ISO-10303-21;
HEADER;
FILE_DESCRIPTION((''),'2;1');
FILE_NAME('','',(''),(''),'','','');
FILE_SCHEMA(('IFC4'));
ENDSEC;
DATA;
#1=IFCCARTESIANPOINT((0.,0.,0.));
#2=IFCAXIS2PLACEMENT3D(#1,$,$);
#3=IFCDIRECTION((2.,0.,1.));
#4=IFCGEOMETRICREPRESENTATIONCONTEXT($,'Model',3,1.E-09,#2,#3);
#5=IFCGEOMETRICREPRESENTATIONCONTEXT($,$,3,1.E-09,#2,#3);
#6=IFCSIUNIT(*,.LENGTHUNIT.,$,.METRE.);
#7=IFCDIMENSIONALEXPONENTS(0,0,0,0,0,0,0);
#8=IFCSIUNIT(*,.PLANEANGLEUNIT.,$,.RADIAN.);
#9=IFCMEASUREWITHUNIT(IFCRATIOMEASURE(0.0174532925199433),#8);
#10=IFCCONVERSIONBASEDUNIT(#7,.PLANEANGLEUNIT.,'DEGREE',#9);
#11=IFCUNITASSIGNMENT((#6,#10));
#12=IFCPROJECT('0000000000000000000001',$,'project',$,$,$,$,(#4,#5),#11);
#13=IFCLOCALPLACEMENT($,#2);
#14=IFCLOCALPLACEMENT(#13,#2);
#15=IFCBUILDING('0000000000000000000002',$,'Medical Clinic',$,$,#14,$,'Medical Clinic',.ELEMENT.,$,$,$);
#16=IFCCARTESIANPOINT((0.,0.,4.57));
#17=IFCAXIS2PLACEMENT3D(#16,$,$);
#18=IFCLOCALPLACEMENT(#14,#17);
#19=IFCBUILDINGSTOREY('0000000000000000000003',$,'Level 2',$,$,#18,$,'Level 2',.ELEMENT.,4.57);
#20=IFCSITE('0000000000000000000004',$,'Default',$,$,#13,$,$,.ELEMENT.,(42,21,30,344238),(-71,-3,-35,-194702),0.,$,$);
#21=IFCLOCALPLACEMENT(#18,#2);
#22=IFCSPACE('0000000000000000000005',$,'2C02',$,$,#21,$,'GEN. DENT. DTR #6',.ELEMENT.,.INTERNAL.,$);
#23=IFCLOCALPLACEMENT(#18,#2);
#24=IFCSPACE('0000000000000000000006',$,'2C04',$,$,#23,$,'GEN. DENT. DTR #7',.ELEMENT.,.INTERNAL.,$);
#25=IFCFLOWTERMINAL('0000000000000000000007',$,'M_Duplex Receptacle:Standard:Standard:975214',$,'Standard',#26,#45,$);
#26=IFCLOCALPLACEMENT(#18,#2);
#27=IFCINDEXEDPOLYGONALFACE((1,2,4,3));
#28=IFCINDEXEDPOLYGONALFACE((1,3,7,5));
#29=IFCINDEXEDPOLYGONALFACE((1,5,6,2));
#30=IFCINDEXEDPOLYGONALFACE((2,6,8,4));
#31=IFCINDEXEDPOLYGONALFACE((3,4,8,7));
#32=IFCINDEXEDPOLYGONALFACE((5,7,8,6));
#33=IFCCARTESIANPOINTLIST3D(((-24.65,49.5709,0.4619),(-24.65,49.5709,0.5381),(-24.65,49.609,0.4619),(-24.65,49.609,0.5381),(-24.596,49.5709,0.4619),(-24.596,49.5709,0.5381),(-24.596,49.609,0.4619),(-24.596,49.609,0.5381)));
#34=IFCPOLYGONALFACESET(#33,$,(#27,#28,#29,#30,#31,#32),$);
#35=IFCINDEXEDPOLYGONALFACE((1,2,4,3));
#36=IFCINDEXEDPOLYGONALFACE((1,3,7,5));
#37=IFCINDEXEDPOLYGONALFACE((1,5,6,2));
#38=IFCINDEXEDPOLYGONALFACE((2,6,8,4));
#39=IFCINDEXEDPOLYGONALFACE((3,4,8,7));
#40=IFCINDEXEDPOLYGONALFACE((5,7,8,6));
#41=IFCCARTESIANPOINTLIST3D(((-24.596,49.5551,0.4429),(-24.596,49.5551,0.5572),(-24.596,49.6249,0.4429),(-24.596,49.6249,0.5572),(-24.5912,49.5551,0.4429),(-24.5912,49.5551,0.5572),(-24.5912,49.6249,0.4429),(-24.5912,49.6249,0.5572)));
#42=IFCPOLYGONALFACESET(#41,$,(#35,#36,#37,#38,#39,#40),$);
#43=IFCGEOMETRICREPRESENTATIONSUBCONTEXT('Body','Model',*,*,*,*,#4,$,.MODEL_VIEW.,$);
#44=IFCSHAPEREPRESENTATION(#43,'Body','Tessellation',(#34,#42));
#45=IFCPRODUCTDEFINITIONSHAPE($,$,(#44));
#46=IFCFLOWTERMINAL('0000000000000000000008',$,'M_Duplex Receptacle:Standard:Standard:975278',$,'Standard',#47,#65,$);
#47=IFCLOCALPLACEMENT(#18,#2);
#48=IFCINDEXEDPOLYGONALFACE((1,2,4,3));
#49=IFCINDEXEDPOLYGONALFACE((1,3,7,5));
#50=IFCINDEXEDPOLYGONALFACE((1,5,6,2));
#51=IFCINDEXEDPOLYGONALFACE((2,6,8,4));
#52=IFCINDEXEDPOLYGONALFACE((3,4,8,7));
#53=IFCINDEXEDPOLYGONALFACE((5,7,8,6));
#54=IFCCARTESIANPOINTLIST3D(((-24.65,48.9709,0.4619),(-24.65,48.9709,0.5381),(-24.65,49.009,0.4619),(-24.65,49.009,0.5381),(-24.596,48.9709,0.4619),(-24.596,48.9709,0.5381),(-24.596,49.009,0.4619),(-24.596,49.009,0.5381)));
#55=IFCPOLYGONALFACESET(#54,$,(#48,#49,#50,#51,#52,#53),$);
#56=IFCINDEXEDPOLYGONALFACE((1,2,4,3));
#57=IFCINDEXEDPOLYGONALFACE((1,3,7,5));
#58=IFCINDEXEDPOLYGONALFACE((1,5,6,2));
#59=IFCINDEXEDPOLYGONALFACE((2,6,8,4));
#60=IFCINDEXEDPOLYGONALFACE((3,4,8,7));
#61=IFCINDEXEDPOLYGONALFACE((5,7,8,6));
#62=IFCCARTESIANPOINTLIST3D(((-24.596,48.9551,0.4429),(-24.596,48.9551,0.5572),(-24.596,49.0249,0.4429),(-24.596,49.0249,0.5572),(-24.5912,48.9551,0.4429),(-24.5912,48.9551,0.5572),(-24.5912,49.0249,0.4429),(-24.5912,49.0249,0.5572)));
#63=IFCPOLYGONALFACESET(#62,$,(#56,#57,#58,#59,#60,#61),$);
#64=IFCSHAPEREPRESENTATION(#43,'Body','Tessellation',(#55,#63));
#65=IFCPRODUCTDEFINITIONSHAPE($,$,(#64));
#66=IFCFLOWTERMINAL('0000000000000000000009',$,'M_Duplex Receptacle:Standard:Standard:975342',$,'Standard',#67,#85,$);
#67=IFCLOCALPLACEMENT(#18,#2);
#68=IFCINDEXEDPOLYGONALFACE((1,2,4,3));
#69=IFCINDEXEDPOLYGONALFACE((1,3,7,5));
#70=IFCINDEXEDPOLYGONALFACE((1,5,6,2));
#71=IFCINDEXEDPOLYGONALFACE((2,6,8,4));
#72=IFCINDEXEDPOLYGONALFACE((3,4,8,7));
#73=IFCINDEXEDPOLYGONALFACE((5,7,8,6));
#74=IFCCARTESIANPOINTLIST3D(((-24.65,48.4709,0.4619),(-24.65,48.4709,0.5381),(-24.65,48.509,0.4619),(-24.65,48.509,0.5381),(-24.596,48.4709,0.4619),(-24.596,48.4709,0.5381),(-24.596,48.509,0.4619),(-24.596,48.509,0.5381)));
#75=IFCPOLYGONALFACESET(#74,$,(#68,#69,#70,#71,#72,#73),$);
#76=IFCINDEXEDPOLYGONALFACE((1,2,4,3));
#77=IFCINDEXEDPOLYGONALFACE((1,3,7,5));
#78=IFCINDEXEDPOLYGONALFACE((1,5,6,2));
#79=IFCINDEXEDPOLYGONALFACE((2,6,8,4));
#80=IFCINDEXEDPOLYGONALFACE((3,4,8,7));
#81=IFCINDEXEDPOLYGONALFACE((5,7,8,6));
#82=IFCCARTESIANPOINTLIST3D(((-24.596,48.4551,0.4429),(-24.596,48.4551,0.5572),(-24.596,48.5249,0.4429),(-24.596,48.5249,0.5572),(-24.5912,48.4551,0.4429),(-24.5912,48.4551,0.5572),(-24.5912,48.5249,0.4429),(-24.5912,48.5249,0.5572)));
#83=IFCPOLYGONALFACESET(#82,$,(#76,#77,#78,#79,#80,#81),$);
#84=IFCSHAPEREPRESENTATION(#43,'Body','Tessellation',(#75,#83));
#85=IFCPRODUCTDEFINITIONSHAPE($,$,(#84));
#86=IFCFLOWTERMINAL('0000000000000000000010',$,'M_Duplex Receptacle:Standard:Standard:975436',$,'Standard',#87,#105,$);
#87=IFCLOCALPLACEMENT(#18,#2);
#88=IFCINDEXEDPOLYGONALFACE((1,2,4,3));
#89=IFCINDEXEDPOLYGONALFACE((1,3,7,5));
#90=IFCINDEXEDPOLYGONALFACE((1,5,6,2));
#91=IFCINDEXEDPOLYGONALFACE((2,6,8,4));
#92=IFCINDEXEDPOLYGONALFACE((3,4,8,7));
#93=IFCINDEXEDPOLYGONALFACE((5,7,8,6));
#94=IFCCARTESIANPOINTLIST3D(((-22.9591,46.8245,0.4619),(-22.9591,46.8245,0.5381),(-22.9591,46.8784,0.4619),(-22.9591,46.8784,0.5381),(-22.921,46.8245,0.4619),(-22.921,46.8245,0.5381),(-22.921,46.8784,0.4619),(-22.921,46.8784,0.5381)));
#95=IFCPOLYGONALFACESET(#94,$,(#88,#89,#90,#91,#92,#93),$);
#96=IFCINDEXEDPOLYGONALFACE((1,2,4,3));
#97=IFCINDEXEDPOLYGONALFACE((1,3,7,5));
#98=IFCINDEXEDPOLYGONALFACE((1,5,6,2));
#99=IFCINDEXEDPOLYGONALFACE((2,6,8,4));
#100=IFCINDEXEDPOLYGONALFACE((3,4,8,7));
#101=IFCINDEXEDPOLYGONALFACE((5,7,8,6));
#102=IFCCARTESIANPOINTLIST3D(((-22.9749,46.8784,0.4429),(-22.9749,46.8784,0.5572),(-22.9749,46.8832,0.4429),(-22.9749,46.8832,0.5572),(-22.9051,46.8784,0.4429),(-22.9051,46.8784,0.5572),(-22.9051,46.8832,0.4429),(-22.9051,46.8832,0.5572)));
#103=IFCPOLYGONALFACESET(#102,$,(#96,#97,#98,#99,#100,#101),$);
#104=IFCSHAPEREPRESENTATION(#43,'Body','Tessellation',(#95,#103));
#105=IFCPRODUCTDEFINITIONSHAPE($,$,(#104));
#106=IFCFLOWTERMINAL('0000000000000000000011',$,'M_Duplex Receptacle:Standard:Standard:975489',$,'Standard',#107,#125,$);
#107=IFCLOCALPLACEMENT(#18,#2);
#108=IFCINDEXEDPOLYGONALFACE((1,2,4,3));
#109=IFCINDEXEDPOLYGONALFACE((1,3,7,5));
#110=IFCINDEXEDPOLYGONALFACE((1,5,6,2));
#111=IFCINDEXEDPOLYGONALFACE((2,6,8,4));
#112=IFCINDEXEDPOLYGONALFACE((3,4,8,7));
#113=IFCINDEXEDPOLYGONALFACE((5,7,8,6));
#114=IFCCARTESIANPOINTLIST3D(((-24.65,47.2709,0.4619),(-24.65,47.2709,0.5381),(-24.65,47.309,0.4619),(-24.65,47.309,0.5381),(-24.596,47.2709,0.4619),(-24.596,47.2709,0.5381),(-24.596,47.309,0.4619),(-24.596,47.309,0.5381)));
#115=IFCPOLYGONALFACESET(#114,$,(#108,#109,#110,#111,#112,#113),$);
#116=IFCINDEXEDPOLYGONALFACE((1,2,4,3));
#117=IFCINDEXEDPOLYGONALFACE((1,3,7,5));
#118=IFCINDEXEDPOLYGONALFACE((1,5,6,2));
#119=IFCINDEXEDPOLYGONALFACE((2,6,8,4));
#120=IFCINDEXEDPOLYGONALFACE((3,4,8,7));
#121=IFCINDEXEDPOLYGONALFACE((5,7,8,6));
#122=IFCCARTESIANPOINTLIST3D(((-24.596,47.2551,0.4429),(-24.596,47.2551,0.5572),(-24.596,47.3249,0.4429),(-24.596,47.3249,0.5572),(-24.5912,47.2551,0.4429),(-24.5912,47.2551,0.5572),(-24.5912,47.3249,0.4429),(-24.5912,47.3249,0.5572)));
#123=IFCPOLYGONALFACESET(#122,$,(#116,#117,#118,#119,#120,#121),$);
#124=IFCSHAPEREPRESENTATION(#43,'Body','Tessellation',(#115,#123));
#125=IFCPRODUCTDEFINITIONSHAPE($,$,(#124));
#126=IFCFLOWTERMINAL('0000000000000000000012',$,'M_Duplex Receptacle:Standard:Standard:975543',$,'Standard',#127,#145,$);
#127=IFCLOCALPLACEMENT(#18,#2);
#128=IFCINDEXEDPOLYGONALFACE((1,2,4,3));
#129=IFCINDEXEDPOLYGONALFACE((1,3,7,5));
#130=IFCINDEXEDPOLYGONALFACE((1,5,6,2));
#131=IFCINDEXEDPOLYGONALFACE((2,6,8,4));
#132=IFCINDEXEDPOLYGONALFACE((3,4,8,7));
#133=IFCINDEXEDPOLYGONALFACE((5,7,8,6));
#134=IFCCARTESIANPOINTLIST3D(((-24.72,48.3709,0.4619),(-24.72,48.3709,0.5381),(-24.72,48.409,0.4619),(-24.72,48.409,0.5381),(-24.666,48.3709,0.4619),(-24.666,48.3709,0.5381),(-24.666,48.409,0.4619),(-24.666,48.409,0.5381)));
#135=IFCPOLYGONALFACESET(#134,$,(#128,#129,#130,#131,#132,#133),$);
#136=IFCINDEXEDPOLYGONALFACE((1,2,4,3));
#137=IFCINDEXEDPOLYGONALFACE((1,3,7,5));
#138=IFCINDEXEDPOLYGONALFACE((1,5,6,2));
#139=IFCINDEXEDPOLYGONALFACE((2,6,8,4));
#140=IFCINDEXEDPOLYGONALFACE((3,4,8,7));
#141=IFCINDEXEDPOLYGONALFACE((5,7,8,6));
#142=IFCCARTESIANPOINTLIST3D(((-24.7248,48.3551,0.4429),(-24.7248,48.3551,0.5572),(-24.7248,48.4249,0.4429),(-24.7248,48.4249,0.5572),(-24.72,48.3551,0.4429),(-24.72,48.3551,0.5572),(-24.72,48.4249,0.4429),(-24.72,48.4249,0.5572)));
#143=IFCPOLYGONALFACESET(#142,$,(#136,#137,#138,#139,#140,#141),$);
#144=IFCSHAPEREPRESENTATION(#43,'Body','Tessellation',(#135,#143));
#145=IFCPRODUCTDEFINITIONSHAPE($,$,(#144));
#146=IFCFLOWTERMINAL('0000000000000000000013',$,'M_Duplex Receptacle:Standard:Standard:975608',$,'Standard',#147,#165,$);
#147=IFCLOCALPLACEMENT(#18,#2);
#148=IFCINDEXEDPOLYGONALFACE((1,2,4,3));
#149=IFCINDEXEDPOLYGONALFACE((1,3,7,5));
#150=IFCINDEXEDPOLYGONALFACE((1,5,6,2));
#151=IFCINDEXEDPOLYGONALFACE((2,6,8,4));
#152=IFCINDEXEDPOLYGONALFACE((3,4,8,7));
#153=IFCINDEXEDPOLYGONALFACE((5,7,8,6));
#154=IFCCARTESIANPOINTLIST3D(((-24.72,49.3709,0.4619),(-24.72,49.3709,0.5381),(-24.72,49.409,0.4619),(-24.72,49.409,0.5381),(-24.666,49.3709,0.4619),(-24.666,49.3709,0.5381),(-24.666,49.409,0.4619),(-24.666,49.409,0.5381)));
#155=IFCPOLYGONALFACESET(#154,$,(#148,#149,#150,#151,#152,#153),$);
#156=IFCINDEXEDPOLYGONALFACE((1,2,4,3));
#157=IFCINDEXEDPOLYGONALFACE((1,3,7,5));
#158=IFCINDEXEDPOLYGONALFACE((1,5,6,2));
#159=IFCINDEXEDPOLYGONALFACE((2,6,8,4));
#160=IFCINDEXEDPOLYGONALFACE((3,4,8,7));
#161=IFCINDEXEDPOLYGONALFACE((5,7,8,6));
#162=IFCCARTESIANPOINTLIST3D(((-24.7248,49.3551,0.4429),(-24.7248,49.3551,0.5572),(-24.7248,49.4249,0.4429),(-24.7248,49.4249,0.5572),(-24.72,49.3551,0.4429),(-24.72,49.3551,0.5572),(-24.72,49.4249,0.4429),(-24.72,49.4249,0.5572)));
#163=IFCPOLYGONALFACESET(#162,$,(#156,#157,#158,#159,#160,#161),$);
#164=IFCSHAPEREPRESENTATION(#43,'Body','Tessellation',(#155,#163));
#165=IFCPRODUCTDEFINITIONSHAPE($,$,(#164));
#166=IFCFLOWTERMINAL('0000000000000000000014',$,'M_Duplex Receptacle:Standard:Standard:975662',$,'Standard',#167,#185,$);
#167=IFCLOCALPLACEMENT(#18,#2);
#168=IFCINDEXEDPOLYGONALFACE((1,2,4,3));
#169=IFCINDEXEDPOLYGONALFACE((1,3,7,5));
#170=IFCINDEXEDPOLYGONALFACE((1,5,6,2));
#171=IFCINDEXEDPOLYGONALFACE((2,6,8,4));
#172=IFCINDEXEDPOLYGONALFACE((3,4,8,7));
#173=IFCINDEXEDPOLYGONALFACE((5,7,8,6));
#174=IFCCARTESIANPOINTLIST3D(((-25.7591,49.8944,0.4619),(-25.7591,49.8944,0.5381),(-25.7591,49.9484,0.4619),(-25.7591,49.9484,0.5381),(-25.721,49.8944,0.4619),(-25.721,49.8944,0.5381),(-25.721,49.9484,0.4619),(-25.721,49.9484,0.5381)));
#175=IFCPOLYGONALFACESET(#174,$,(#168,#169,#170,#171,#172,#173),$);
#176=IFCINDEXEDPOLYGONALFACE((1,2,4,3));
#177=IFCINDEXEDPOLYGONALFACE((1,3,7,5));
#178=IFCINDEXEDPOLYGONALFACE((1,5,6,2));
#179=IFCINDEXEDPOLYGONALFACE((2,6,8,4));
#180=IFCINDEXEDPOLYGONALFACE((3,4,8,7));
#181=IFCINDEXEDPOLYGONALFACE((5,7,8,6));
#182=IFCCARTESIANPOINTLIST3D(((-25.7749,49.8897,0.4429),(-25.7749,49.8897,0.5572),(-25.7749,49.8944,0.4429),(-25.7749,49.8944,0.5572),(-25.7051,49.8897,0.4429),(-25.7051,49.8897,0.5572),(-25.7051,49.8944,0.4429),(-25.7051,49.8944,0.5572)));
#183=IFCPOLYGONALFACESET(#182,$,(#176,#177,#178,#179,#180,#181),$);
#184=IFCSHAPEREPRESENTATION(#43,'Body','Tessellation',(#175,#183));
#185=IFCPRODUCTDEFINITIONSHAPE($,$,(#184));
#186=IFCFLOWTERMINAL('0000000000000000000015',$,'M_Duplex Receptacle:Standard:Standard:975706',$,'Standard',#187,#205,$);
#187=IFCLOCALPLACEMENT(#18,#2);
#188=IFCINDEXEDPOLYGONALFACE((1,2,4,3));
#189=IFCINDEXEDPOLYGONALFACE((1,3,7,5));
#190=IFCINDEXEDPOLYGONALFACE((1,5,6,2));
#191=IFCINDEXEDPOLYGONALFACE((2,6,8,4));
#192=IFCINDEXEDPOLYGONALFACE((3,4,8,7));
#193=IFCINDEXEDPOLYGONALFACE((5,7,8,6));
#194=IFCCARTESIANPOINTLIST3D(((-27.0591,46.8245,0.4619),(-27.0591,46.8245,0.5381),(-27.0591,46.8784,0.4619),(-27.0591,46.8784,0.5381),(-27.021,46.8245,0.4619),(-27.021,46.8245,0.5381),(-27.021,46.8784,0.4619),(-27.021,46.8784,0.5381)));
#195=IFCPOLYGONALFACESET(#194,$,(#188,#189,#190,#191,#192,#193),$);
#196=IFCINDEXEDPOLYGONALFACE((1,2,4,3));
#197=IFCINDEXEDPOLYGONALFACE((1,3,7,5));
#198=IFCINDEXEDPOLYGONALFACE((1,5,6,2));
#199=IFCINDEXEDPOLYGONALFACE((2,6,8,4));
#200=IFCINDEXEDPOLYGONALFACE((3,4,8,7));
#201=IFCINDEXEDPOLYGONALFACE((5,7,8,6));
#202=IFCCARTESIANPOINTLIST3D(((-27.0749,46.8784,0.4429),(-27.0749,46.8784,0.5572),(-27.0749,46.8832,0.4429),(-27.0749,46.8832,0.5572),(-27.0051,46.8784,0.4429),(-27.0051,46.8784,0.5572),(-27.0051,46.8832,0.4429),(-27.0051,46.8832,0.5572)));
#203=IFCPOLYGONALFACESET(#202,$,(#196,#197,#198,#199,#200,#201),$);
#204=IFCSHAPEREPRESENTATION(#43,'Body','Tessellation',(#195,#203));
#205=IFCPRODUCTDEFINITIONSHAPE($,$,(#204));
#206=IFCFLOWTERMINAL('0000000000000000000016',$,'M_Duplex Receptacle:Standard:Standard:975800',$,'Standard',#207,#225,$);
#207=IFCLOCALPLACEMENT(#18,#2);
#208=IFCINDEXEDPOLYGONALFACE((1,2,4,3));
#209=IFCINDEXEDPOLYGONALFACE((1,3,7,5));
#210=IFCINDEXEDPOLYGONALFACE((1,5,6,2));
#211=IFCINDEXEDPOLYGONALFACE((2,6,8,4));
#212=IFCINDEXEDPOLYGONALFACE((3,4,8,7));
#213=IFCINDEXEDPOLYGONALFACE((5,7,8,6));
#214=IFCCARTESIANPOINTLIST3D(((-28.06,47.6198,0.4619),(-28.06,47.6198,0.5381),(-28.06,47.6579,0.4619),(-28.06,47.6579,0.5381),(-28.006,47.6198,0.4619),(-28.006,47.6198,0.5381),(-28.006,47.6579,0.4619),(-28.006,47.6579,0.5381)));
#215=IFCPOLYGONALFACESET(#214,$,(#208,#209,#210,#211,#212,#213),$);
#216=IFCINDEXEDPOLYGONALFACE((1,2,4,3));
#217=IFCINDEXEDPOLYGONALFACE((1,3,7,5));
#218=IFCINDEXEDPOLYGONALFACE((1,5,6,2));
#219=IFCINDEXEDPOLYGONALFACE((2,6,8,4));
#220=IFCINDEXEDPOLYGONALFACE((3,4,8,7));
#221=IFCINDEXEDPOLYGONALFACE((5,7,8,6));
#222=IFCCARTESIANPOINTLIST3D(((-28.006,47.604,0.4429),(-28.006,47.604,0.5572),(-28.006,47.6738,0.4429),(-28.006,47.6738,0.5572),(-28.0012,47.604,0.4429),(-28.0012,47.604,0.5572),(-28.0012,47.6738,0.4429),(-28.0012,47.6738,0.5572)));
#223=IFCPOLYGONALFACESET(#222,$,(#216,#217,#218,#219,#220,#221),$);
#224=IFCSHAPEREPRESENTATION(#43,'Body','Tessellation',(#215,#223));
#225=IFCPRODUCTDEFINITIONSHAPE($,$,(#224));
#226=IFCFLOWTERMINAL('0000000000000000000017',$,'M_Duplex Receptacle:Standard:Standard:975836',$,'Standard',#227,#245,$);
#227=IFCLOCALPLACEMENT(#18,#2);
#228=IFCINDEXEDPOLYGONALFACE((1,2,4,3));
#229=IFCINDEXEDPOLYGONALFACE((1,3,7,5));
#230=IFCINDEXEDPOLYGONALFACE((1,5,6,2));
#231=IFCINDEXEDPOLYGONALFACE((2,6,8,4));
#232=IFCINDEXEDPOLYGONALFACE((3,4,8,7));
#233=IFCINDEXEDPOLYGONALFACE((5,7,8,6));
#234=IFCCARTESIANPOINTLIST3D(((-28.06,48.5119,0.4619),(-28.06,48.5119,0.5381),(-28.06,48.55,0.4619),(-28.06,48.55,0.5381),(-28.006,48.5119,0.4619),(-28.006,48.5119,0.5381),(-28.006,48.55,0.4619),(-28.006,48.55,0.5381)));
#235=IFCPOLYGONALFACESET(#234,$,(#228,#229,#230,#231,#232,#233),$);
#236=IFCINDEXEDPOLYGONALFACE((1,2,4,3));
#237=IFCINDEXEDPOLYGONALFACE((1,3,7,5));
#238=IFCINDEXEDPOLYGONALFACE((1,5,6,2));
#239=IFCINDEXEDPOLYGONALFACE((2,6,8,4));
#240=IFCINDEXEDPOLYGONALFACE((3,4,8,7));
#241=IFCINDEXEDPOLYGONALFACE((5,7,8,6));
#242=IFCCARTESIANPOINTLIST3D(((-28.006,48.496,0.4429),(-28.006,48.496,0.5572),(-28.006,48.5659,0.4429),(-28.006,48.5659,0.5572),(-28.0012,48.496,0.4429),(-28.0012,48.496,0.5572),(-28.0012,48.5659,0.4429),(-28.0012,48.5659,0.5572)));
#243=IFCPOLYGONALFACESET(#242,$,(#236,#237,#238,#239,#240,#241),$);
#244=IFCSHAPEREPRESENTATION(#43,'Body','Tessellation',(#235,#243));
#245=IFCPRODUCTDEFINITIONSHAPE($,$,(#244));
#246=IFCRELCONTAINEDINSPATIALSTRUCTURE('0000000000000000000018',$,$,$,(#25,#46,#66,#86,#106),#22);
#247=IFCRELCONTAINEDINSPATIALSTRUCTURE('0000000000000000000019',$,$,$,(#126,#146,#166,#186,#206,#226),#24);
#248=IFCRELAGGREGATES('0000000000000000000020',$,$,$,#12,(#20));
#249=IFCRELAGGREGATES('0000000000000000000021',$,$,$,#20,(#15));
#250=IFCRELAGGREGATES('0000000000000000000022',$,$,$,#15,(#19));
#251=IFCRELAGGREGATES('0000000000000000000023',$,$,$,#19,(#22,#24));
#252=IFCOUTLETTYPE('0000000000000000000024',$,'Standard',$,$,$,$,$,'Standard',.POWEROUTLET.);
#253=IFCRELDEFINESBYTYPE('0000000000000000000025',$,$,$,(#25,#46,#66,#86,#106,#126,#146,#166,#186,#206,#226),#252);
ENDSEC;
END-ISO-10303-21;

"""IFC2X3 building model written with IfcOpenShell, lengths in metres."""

from ifc_helpers import new_model, entity, si_unit, converted_unit, direction, frame, frame_2d, origin, origin_2d_with_axis, place, context, subcontext, project, spatial, rectangle, extrude, source, transform, mapped, type_object, type_shapes, element, save


model = new_model("IFC2X3")

# Units and contexts
model_context = context("Model", 3, precision=1e-09, world=origin(), true_north=direction((2.0, 0.0, 1.0)))
context_of_model = context(None, 3, precision=1e-09, world=origin(), true_north=direction((2.0, 0.0, 1.0)))
body_context = subcontext(model_context, "Body", "Model", "MODEL_VIEW")
ifc_project = project(units=[si_unit("LENGTHUNIT", "METRE"), converted_unit("PLANEANGLEUNIT", "DEGREE", entity("IfcRatioMeasure", 0.0174532925199433), si_unit("PLANEANGLEUNIT", "RADIAN"), dimensions=[0, 0, 0, 0, 0, 0, 0])], contexts=[model_context, context_of_model])

# Site, building, storey, space
site_placement = place(None, origin())
site = spatial("IfcSite", under=ifc_project, at=site_placement, Name="Default", CompositionType="ELEMENT", RefLatitude=(42, 21, 30, 344238), RefLongitude=(-71, -3, -35, -194702), RefElevation=0.0)
building_placement = place(site_placement, origin())
building = spatial("IfcBuilding", under=site, at=building_placement, Name="Medical Clinic", LongName="Medical Clinic", CompositionType="ELEMENT")
storey_placement = place(building_placement, frame((0.0, 0.0, 4.57)))
storey = spatial("IfcBuildingStorey", under=building, at=storey_placement, Name="Level 2", LongName="Level 2", CompositionType="ELEMENT", Elevation=4.57)
space_1_placement = place(storey_placement, origin())
space_1 = spatial("IfcSpace", under=storey, at=space_1_placement, Name="2C02", LongName="GEN. DENT. DTR #6", CompositionType="ELEMENT", InteriorOrExteriorSpace="INTERNAL")

# Flow terminals
outlet_type = type_object("IfcOutletType", Name="Standard", ElementType="Standard", PredefinedType="POWEROUTLET")
shared_shape_1 = source(origin(), body_context, "Body", "SweptSolid", [
    extrude(rectangle(XDim=0.0381, YDim=0.0762, at=origin_2d_with_axis()), frame((0.0, 0.0, -0.054), z_axis=(0.0, 0.0, 1.0), x_axis=(-1.0, 0.0, 0.0)), (0.0, 0.0, 1.0), 0.054),
    extrude(rectangle(XDim=0.0698, YDim=0.1143, at=frame_2d((0.0, 0.0), x_axis=(1.0, 0.0))), frame((0.0, 0.0, 0.0), z_axis=(0.0, 0.0, 1.0), x_axis=(-1.0, 0.0, 0.0)), (0.0, 0.0, 1.0), 0.0048),
])
type_shapes(outlet_type, [shared_shape_1])
for number, where, z_axis, x_axis, name in (
    (1, (-24.596, 49.59, 0.5), (1.0, 0.0, 0.0), (0.0, 1.0, 0.0), "M_Duplex Receptacle:Standard:Standard:975214"),
    (2, (-24.596, 48.99, 0.5), (1.0, 0.0, 0.0), (0.0, 1.0, 0.0), "M_Duplex Receptacle:Standard:Standard:975278"),
    (3, (-24.596, 48.49, 0.5), (1.0, 0.0, 0.0), (0.0, 1.0, 0.0), "M_Duplex Receptacle:Standard:Standard:975342"),
    (4, (-22.94, 46.8784, 0.5), (0.0, 1.0, 0.0), (-1.0, 0.0, 0.0), "M_Duplex Receptacle:Standard:Standard:975436"),
    (5, (-24.596, 47.29, 0.5), (1.0, 0.0, 0.0), (0.0, 1.0, 0.0), "M_Duplex Receptacle:Standard:Standard:975489"),
):
    element("IfcFlowTerminal", number, at=place(space_1_placement, frame(where, z_axis=z_axis, x_axis=x_axis)), inside=space_1, type_object=outlet_type, Name=name, ObjectType="Standard", context=body_context, shape_type="MappedRepresentation", body=[
        mapped(shared_shape_1, transform((0.0, 0.0, 0.0), scale=1.0)),
    ])

# Shared definitions
space_2_placement = place(storey_placement, origin())
space_2 = spatial("IfcSpace", under=storey, at=space_2_placement, Name="2C04", LongName="GEN. DENT. DTR #7", CompositionType="ELEMENT", InteriorOrExteriorSpace="INTERNAL")

# Flow terminals
for number, where, z_axis, x_axis, name in (
    (6, (-24.72, 48.39, 0.5), (-1.0, 0.0, 0.0), (0.0, -1.0, 0.0), "M_Duplex Receptacle:Standard:Standard:975543"),
    (7, (-24.72, 49.39, 0.5), (-1.0, 0.0, 0.0), (0.0, -1.0, 0.0), "M_Duplex Receptacle:Standard:Standard:975608"),
    (8, (-25.74, 49.8944, 0.5), (0.0, -1.0, 0.0), (1.0, 0.0, 0.0), "M_Duplex Receptacle:Standard:Standard:975662"),
    (9, (-27.04, 46.8784, 0.5), (0.0, 1.0, 0.0), (-1.0, 0.0, 0.0), "M_Duplex Receptacle:Standard:Standard:975706"),
    (10, (-28.006, 47.6389, 0.5), (1.0, 0.0, 0.0), (0.0, 1.0, 0.0), "M_Duplex Receptacle:Standard:Standard:975800"),
    (11, (-28.006, 48.5309, 0.5), (1.0, 0.0, 0.0), (0.0, 1.0, 0.0), "M_Duplex Receptacle:Standard:Standard:975836"),
):
    element("IfcFlowTerminal", number, at=place(space_2_placement, frame(where, z_axis=z_axis, x_axis=x_axis)), inside=space_2, type_object=outlet_type, Name=name, ObjectType="Standard", context=body_context, shape_type="MappedRepresentation", body=[
        mapped(shared_shape_1, transform((0.0, 0.0, 0.0), scale=1.0)),
    ])

save(model, "model.ifc")
